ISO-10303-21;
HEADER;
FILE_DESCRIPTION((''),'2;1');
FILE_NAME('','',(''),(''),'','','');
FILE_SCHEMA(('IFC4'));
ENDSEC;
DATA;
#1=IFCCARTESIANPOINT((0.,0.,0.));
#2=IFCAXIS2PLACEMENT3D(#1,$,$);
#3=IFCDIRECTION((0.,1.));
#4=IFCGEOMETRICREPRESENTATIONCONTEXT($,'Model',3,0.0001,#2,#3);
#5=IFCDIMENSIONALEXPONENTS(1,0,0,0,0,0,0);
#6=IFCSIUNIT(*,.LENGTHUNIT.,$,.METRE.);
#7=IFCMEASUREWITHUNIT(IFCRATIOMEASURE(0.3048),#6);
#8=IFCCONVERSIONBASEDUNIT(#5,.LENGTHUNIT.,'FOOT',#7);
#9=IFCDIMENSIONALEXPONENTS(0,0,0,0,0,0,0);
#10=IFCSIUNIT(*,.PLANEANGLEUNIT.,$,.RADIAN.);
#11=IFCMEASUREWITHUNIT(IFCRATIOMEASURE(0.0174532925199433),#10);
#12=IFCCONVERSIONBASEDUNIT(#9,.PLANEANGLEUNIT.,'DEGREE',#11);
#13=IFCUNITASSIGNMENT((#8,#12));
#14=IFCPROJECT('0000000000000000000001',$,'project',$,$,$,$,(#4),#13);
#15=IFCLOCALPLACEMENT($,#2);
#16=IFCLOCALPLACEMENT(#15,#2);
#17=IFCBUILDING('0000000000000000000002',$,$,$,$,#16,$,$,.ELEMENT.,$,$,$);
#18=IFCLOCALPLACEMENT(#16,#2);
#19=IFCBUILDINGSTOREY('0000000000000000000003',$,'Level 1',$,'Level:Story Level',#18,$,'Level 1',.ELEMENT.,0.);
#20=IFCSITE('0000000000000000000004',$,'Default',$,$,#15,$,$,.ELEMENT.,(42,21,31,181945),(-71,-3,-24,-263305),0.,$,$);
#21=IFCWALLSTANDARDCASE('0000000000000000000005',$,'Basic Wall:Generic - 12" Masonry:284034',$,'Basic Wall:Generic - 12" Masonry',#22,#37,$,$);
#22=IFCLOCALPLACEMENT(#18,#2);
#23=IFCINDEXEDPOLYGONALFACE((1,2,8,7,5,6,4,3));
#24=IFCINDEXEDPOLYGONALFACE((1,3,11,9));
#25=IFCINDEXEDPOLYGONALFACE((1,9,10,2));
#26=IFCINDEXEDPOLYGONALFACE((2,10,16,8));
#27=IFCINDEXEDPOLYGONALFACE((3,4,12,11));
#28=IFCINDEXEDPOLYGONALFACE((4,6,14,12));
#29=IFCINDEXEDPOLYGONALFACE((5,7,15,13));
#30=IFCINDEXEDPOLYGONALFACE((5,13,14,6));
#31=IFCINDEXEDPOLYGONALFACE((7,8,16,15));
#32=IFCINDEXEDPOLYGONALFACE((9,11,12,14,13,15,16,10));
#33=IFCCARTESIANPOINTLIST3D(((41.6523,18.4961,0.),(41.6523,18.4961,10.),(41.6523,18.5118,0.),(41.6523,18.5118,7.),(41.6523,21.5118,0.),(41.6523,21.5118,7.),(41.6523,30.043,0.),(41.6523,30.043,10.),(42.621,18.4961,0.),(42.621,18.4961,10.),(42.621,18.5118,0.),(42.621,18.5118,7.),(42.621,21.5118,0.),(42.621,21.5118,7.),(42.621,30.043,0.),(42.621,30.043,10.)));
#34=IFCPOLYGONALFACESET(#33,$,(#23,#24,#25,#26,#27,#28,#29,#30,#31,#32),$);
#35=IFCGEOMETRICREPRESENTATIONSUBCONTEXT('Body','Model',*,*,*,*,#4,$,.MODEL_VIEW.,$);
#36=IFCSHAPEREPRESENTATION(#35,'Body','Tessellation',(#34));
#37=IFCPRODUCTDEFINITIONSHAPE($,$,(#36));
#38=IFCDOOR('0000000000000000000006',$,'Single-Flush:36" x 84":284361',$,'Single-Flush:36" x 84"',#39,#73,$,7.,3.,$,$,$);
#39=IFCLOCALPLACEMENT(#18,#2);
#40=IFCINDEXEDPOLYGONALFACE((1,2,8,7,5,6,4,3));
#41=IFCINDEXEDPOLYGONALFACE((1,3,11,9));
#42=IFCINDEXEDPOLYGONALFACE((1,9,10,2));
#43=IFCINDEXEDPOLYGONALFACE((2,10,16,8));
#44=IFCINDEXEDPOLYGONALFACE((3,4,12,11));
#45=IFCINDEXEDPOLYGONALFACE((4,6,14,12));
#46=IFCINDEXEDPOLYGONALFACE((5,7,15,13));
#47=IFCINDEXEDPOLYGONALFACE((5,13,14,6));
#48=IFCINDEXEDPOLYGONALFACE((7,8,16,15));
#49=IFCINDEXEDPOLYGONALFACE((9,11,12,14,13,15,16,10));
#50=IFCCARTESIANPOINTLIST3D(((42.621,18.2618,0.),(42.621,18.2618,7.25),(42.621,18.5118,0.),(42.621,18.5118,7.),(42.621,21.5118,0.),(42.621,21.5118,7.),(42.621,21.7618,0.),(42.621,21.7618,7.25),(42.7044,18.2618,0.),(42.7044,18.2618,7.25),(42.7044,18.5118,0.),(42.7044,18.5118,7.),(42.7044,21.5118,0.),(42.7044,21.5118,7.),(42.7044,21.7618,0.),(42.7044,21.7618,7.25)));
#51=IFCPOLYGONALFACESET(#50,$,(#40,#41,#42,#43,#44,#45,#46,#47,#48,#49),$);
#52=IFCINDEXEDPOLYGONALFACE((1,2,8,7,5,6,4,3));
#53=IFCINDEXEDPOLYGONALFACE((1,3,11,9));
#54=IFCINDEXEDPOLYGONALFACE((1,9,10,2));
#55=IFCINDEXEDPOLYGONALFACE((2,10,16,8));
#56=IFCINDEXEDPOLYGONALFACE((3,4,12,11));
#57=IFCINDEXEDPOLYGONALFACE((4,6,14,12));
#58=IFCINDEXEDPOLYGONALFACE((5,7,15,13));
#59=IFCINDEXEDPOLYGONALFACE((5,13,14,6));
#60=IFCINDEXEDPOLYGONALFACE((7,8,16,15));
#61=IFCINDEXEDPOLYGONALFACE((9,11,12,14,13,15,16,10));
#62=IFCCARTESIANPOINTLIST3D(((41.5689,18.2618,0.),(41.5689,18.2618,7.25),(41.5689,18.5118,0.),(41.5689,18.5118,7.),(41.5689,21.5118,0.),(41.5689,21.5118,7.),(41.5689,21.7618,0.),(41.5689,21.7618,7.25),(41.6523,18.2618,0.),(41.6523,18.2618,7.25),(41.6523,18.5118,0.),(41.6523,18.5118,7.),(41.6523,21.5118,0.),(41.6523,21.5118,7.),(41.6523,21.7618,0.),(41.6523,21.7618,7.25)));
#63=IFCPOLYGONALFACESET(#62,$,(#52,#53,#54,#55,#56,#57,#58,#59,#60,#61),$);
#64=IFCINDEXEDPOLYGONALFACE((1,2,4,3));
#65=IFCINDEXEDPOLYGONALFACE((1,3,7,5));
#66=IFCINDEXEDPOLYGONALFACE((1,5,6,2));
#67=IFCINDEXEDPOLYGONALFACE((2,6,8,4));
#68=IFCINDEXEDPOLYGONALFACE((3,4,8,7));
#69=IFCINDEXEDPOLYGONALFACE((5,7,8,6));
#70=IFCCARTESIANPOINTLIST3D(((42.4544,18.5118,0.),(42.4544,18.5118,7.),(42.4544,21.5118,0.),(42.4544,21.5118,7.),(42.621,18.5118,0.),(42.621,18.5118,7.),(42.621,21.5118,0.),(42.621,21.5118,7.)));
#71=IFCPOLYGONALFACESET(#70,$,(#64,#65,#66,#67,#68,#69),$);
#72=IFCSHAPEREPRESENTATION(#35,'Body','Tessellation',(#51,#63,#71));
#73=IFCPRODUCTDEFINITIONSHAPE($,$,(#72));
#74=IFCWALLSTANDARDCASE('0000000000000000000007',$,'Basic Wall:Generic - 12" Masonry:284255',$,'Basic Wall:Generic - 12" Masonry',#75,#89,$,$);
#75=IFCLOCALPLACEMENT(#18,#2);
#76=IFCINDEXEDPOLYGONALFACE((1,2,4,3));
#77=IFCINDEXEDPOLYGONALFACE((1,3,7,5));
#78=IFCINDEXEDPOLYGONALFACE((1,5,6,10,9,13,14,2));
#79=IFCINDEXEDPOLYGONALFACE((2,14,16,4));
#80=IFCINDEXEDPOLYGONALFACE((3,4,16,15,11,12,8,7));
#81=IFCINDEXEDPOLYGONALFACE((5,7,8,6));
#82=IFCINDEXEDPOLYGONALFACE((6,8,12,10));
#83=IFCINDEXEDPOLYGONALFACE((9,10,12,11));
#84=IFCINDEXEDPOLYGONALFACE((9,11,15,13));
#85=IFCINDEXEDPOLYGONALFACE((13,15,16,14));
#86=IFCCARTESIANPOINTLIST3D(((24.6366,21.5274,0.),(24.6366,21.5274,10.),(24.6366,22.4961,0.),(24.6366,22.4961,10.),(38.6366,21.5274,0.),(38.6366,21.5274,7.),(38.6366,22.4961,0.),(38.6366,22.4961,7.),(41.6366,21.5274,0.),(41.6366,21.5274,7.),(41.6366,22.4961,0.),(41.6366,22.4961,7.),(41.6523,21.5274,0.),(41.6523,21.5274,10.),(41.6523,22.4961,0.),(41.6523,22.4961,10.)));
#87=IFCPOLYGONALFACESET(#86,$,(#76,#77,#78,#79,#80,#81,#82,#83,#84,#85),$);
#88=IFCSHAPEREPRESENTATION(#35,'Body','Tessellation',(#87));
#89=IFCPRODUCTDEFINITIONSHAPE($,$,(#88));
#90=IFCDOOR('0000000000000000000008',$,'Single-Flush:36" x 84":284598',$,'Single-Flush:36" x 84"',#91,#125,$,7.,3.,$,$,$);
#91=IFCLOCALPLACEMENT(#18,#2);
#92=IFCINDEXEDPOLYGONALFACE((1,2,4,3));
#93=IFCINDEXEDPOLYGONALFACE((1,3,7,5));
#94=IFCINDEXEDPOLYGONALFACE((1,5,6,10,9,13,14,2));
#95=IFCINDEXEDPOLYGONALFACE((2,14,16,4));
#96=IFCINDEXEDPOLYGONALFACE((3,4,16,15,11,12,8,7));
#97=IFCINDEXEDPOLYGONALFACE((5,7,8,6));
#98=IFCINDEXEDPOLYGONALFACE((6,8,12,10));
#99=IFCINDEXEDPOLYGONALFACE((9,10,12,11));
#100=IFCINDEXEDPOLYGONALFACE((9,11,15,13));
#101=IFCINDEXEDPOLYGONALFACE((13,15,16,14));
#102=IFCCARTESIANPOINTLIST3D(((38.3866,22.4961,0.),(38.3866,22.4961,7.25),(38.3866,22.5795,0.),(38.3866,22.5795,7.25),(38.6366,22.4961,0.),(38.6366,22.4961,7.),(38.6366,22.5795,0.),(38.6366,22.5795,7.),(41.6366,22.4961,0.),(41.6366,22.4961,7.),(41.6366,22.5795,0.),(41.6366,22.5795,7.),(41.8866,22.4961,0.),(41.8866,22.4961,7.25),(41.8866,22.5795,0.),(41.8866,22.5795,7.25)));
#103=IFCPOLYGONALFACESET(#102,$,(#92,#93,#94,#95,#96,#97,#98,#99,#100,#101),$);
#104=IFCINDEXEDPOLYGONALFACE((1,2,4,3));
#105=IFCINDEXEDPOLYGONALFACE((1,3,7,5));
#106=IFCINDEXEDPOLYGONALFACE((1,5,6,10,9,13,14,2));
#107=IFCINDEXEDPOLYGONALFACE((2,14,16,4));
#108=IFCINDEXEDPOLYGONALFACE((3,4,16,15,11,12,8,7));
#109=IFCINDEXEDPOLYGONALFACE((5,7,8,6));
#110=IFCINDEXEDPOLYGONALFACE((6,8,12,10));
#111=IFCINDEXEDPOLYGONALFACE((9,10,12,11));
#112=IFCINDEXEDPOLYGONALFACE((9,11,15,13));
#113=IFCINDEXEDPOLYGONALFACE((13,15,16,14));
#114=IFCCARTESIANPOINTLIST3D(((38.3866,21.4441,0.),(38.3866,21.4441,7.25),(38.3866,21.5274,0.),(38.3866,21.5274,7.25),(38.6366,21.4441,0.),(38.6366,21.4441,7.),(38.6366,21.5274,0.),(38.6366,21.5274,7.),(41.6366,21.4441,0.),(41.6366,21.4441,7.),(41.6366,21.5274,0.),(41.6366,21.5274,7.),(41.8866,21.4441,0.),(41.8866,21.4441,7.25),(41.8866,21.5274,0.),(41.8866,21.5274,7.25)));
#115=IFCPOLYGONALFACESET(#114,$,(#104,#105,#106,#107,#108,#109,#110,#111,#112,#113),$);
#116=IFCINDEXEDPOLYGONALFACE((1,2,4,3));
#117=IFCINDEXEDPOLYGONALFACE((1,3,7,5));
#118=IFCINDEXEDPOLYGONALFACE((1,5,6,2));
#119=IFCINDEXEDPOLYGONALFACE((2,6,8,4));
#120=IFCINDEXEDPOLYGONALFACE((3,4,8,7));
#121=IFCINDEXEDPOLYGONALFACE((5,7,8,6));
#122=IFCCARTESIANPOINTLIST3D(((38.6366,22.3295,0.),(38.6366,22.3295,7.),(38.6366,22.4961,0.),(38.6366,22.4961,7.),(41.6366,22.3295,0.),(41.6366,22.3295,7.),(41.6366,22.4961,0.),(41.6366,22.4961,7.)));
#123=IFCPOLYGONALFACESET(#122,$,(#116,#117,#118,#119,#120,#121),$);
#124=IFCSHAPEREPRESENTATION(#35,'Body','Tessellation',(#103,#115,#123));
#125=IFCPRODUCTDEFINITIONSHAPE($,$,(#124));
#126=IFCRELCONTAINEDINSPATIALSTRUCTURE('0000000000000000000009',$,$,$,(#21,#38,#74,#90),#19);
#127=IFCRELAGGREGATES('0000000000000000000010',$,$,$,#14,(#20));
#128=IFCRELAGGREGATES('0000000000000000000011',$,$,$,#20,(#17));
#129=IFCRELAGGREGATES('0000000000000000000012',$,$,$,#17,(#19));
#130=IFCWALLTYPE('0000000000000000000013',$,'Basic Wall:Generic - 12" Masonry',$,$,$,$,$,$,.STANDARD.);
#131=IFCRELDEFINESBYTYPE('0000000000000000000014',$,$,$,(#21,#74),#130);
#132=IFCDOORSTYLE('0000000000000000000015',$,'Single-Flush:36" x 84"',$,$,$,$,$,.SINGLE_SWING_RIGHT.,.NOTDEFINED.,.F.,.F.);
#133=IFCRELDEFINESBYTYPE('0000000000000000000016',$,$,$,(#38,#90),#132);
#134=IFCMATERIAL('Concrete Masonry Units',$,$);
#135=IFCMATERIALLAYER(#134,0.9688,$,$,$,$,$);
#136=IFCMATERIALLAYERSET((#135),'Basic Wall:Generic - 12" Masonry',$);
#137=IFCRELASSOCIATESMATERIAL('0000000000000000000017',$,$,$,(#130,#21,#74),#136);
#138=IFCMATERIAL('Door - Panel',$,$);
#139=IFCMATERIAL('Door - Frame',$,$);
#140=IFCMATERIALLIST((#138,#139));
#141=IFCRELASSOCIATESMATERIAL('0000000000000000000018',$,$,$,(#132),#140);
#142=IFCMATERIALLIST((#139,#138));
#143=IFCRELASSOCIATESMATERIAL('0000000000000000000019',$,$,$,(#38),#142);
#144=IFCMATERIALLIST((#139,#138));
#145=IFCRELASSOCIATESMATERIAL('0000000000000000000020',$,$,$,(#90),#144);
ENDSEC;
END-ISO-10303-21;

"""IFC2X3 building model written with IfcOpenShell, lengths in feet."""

from ifc_helpers import new_model, entity, si_unit, converted_unit, direction, frame, frame_2d, origin, place, context, subcontext, project, spatial, polyline, rectangle, outline, extrude, source, transform, mapped, material, material_list, layer, layer_set, layer_usage, type_object, type_shapes, element, fill, save


model = new_model("IFC2X3")

# Units and contexts
model_context = context("Model", 3, precision=0.0001, world=origin(), true_north=direction((0.0, 1.0)))
body_context = subcontext(model_context, "Body", "Model", "MODEL_VIEW")
ifc_project = project(units=[converted_unit("LENGTHUNIT", "FOOT", entity("IfcRatioMeasure", 0.3048), si_unit("LENGTHUNIT", "METRE"), dimensions=[1, 0, 0, 0, 0, 0, 0]), converted_unit("PLANEANGLEUNIT", "DEGREE", entity("IfcRatioMeasure", 0.0174532925199433), si_unit("PLANEANGLEUNIT", "RADIAN"), dimensions=[0, 0, 0, 0, 0, 0, 0])], contexts=[model_context])

# Site, building, storey
site_placement = place(None, origin())
site = spatial("IfcSite", under=ifc_project, at=site_placement, Name="Default", CompositionType="ELEMENT", RefLatitude=(42, 21, 31, 181945), RefLongitude=(-71, -3, -24, -263305), RefElevation=0.0)
building_placement = place(site_placement, origin())
building = spatial("IfcBuilding", under=site, at=building_placement, CompositionType="ELEMENT")
storey_placement = place(building_placement, origin())
storey = spatial("IfcBuildingStorey", under=building, at=storey_placement, Name="Level 1", ObjectType="Level:Story Level", LongName="Level 1", CompositionType="ELEMENT", Elevation=0.0)

# Shared definitions
ifc_material_1 = material(Name="Concrete Masonry Units")
ifc_layer_1 = layer(ifc_material_1, 0.9688)
ifc_layer_set_1 = layer_set([ifc_layer_1], Name="Basic Wall:Generic - 12\" Masonry")
wall_type = type_object("IfcWallType", Name="Basic Wall:Generic - 12\" Masonry", PredefinedType="STANDARD", material=ifc_layer_set_1)

# Shared definitions
ifc_material_2 = material(Name="Door - Frame")
ifc_material_3 = material(Name="Door - Panel")
ifc_material_list_1 = material_list([ifc_material_3, ifc_material_2])
door_style_1 = type_object("IfcDoorStyle", Name="Single-Flush:36\" x 84\"", ConstructionType="NOTDEFINED", OperationType="SINGLE_SWING_RIGHT", ParameterTakesPrecedence=False, Sizeable=False, material=ifc_material_list_1)
shared_shape_1 = source(origin(), body_context, "Body", "SweptSolid", [
    extrude(outline(polyline([(-1.75, -3.6875), (1.75, -3.6875), (1.75, 3.5625), (1.5, 3.5625), (1.5, -3.4375), (-1.5, -3.4375), (-1.5, 3.5625), (-1.75, 3.5625), (-1.75, -3.6875)])), frame((1.5, 0.9688, 3.5625), z_axis=(0.0, 1.0, 0.0), x_axis=(1.0, 0.0, 0.0)), (0.0, 0.0, 1.0), 0.0833),
    extrude(outline(polyline([(-3.6875, -1.75), (3.5625, -1.75), (3.5625, -1.5), (-3.4375, -1.5), (-3.4375, 1.5), (3.5625, 1.5), (3.5625, 1.75), (-3.6875, 1.75), (-3.6875, -1.75)])), frame((1.5, -0.0833, 3.5625), z_axis=(0.0, 1.0, 0.0), x_axis=(0.0, 0.0, -1.0)), (0.0, 0.0, 1.0), 0.0833),
    extrude(rectangle(XDim=0.1667, YDim=3.0, at=frame_2d((0.0, 0.0), x_axis=(1.0, 0.0))), frame((1.5, 0.8854, 0.0), z_axis=(0.0, 0.0, 1.0), x_axis=(0.0, 1.0, 0.0)), (0.0, 0.0, 1.0), 7.0),
])
type_shapes(door_style_1, [shared_shape_1])

# Walls, openings, doors
ifc_layer_usage_1 = layer_usage(ifc_layer_set_1, "AXIS2", "NEGATIVE", 0.4844)
wall_1_placement = place(storey_placement, frame((42.1366, 18.4961, 0.0), z_axis=(0.0, 0.0, 1.0), x_axis=(0.0, 1.0, 0.0)))
wall_1 = element("IfcWallStandardCase", 1, at=wall_1_placement, inside=storey, type_object=wall_type, material=ifc_layer_usage_1, Name="Basic Wall:Generic - 12\" Masonry:284034", ObjectType="Basic Wall:Generic - 12\" Masonry", context=body_context, shape_type="SweptSolid", body=[
    extrude(rectangle(XDim=11.5468, YDim=0.9688, at=frame_2d((5.7734, 0.0), x_axis=(-1.0, 0.0))), origin(), (0.0, 0.0, 1.0), 10.0),
])
opening_1_placement = place(wall_1_placement, frame((3.0156, 0.4844, 0.0)))
opening_1 = element("IfcOpeningElement", 2, at=opening_1_placement, cuts=wall_1, ObjectType="Opening", context=body_context, shape_type="SweptSolid", body=[
    extrude(rectangle(XDim=3.0, YDim=7.0, at=frame_2d((3.5, 1.5), x_axis=(0.0, 1.0))), frame((0.0, 0.0, 0.0), z_axis=(0.0, -1.0, 0.0), x_axis=(0.0, 0.0, 1.0)), (0.0, 0.0, 1.0), 0.9688),
])
ifc_material_list_2 = material_list([ifc_material_2, ifc_material_3])
door_1_placement = place(opening_1_placement, frame((0.0, 0.0, 0.0), z_axis=(0.0, 0.0, 1.0), x_axis=(-1.0, 0.0, 0.0)))
door_1 = element("IfcDoor", 3, at=door_1_placement, inside=storey, type_object=door_style_1, material=ifc_material_list_2, Name="Single-Flush:36\" x 84\":284361", ObjectType="Single-Flush:36\" x 84\"", OverallHeight=7.0, OverallWidth=3.0, context=body_context, shape_type="MappedRepresentation", body=[
    mapped(shared_shape_1, transform((0.0, 0.0, 0.0), scale=1.0)),
])
fill(opening_1, door_1)
ifc_layer_usage_2 = layer_usage(ifc_layer_set_1, "AXIS2", "NEGATIVE", 0.4844)
wall_2_placement = place(storey_placement, frame((24.6366, 22.0118, 0.0)))
wall_2 = element("IfcWallStandardCase", 4, at=wall_2_placement, inside=storey, type_object=wall_type, material=ifc_layer_usage_2, Name="Basic Wall:Generic - 12\" Masonry:284255", ObjectType="Basic Wall:Generic - 12\" Masonry", context=body_context, shape_type="SweptSolid", body=[
    extrude(rectangle(XDim=17.0156, YDim=0.9688, at=frame_2d((8.5078, 0.0), x_axis=(-1.0, 0.0))), origin(), (0.0, 0.0, 1.0), 10.0),
])
opening_2_placement = place(wall_2_placement, frame((14.0, -0.4844, 0.0)))
opening_2 = element("IfcOpeningElement", 5, at=opening_2_placement, cuts=wall_2, ObjectType="Opening", context=body_context, shape_type="SweptSolid", body=[
    extrude(rectangle(XDim=3.0, YDim=7.0, at=frame_2d((3.5, 1.5), x_axis=(0.0, 1.0))), frame((0.0, 0.0, 0.0), z_axis=(0.0, 1.0, 0.0), x_axis=(0.0, 0.0, 1.0)), (0.0, 0.0, 1.0), 0.9688),
])
ifc_material_list_3 = material_list([ifc_material_2, ifc_material_3])
door_2_placement = place(opening_2_placement, origin())
door_2 = element("IfcDoor", 6, at=door_2_placement, inside=storey, type_object=door_style_1, material=ifc_material_list_3, Name="Single-Flush:36\" x 84\":284598", ObjectType="Single-Flush:36\" x 84\"", OverallHeight=7.0, OverallWidth=3.0, context=body_context, shape_type="MappedRepresentation", body=[
    mapped(shared_shape_1, transform((0.0, 0.0, 0.0), scale=1.0)),
])
fill(opening_2, door_2)

save(model, "model.ifc")
